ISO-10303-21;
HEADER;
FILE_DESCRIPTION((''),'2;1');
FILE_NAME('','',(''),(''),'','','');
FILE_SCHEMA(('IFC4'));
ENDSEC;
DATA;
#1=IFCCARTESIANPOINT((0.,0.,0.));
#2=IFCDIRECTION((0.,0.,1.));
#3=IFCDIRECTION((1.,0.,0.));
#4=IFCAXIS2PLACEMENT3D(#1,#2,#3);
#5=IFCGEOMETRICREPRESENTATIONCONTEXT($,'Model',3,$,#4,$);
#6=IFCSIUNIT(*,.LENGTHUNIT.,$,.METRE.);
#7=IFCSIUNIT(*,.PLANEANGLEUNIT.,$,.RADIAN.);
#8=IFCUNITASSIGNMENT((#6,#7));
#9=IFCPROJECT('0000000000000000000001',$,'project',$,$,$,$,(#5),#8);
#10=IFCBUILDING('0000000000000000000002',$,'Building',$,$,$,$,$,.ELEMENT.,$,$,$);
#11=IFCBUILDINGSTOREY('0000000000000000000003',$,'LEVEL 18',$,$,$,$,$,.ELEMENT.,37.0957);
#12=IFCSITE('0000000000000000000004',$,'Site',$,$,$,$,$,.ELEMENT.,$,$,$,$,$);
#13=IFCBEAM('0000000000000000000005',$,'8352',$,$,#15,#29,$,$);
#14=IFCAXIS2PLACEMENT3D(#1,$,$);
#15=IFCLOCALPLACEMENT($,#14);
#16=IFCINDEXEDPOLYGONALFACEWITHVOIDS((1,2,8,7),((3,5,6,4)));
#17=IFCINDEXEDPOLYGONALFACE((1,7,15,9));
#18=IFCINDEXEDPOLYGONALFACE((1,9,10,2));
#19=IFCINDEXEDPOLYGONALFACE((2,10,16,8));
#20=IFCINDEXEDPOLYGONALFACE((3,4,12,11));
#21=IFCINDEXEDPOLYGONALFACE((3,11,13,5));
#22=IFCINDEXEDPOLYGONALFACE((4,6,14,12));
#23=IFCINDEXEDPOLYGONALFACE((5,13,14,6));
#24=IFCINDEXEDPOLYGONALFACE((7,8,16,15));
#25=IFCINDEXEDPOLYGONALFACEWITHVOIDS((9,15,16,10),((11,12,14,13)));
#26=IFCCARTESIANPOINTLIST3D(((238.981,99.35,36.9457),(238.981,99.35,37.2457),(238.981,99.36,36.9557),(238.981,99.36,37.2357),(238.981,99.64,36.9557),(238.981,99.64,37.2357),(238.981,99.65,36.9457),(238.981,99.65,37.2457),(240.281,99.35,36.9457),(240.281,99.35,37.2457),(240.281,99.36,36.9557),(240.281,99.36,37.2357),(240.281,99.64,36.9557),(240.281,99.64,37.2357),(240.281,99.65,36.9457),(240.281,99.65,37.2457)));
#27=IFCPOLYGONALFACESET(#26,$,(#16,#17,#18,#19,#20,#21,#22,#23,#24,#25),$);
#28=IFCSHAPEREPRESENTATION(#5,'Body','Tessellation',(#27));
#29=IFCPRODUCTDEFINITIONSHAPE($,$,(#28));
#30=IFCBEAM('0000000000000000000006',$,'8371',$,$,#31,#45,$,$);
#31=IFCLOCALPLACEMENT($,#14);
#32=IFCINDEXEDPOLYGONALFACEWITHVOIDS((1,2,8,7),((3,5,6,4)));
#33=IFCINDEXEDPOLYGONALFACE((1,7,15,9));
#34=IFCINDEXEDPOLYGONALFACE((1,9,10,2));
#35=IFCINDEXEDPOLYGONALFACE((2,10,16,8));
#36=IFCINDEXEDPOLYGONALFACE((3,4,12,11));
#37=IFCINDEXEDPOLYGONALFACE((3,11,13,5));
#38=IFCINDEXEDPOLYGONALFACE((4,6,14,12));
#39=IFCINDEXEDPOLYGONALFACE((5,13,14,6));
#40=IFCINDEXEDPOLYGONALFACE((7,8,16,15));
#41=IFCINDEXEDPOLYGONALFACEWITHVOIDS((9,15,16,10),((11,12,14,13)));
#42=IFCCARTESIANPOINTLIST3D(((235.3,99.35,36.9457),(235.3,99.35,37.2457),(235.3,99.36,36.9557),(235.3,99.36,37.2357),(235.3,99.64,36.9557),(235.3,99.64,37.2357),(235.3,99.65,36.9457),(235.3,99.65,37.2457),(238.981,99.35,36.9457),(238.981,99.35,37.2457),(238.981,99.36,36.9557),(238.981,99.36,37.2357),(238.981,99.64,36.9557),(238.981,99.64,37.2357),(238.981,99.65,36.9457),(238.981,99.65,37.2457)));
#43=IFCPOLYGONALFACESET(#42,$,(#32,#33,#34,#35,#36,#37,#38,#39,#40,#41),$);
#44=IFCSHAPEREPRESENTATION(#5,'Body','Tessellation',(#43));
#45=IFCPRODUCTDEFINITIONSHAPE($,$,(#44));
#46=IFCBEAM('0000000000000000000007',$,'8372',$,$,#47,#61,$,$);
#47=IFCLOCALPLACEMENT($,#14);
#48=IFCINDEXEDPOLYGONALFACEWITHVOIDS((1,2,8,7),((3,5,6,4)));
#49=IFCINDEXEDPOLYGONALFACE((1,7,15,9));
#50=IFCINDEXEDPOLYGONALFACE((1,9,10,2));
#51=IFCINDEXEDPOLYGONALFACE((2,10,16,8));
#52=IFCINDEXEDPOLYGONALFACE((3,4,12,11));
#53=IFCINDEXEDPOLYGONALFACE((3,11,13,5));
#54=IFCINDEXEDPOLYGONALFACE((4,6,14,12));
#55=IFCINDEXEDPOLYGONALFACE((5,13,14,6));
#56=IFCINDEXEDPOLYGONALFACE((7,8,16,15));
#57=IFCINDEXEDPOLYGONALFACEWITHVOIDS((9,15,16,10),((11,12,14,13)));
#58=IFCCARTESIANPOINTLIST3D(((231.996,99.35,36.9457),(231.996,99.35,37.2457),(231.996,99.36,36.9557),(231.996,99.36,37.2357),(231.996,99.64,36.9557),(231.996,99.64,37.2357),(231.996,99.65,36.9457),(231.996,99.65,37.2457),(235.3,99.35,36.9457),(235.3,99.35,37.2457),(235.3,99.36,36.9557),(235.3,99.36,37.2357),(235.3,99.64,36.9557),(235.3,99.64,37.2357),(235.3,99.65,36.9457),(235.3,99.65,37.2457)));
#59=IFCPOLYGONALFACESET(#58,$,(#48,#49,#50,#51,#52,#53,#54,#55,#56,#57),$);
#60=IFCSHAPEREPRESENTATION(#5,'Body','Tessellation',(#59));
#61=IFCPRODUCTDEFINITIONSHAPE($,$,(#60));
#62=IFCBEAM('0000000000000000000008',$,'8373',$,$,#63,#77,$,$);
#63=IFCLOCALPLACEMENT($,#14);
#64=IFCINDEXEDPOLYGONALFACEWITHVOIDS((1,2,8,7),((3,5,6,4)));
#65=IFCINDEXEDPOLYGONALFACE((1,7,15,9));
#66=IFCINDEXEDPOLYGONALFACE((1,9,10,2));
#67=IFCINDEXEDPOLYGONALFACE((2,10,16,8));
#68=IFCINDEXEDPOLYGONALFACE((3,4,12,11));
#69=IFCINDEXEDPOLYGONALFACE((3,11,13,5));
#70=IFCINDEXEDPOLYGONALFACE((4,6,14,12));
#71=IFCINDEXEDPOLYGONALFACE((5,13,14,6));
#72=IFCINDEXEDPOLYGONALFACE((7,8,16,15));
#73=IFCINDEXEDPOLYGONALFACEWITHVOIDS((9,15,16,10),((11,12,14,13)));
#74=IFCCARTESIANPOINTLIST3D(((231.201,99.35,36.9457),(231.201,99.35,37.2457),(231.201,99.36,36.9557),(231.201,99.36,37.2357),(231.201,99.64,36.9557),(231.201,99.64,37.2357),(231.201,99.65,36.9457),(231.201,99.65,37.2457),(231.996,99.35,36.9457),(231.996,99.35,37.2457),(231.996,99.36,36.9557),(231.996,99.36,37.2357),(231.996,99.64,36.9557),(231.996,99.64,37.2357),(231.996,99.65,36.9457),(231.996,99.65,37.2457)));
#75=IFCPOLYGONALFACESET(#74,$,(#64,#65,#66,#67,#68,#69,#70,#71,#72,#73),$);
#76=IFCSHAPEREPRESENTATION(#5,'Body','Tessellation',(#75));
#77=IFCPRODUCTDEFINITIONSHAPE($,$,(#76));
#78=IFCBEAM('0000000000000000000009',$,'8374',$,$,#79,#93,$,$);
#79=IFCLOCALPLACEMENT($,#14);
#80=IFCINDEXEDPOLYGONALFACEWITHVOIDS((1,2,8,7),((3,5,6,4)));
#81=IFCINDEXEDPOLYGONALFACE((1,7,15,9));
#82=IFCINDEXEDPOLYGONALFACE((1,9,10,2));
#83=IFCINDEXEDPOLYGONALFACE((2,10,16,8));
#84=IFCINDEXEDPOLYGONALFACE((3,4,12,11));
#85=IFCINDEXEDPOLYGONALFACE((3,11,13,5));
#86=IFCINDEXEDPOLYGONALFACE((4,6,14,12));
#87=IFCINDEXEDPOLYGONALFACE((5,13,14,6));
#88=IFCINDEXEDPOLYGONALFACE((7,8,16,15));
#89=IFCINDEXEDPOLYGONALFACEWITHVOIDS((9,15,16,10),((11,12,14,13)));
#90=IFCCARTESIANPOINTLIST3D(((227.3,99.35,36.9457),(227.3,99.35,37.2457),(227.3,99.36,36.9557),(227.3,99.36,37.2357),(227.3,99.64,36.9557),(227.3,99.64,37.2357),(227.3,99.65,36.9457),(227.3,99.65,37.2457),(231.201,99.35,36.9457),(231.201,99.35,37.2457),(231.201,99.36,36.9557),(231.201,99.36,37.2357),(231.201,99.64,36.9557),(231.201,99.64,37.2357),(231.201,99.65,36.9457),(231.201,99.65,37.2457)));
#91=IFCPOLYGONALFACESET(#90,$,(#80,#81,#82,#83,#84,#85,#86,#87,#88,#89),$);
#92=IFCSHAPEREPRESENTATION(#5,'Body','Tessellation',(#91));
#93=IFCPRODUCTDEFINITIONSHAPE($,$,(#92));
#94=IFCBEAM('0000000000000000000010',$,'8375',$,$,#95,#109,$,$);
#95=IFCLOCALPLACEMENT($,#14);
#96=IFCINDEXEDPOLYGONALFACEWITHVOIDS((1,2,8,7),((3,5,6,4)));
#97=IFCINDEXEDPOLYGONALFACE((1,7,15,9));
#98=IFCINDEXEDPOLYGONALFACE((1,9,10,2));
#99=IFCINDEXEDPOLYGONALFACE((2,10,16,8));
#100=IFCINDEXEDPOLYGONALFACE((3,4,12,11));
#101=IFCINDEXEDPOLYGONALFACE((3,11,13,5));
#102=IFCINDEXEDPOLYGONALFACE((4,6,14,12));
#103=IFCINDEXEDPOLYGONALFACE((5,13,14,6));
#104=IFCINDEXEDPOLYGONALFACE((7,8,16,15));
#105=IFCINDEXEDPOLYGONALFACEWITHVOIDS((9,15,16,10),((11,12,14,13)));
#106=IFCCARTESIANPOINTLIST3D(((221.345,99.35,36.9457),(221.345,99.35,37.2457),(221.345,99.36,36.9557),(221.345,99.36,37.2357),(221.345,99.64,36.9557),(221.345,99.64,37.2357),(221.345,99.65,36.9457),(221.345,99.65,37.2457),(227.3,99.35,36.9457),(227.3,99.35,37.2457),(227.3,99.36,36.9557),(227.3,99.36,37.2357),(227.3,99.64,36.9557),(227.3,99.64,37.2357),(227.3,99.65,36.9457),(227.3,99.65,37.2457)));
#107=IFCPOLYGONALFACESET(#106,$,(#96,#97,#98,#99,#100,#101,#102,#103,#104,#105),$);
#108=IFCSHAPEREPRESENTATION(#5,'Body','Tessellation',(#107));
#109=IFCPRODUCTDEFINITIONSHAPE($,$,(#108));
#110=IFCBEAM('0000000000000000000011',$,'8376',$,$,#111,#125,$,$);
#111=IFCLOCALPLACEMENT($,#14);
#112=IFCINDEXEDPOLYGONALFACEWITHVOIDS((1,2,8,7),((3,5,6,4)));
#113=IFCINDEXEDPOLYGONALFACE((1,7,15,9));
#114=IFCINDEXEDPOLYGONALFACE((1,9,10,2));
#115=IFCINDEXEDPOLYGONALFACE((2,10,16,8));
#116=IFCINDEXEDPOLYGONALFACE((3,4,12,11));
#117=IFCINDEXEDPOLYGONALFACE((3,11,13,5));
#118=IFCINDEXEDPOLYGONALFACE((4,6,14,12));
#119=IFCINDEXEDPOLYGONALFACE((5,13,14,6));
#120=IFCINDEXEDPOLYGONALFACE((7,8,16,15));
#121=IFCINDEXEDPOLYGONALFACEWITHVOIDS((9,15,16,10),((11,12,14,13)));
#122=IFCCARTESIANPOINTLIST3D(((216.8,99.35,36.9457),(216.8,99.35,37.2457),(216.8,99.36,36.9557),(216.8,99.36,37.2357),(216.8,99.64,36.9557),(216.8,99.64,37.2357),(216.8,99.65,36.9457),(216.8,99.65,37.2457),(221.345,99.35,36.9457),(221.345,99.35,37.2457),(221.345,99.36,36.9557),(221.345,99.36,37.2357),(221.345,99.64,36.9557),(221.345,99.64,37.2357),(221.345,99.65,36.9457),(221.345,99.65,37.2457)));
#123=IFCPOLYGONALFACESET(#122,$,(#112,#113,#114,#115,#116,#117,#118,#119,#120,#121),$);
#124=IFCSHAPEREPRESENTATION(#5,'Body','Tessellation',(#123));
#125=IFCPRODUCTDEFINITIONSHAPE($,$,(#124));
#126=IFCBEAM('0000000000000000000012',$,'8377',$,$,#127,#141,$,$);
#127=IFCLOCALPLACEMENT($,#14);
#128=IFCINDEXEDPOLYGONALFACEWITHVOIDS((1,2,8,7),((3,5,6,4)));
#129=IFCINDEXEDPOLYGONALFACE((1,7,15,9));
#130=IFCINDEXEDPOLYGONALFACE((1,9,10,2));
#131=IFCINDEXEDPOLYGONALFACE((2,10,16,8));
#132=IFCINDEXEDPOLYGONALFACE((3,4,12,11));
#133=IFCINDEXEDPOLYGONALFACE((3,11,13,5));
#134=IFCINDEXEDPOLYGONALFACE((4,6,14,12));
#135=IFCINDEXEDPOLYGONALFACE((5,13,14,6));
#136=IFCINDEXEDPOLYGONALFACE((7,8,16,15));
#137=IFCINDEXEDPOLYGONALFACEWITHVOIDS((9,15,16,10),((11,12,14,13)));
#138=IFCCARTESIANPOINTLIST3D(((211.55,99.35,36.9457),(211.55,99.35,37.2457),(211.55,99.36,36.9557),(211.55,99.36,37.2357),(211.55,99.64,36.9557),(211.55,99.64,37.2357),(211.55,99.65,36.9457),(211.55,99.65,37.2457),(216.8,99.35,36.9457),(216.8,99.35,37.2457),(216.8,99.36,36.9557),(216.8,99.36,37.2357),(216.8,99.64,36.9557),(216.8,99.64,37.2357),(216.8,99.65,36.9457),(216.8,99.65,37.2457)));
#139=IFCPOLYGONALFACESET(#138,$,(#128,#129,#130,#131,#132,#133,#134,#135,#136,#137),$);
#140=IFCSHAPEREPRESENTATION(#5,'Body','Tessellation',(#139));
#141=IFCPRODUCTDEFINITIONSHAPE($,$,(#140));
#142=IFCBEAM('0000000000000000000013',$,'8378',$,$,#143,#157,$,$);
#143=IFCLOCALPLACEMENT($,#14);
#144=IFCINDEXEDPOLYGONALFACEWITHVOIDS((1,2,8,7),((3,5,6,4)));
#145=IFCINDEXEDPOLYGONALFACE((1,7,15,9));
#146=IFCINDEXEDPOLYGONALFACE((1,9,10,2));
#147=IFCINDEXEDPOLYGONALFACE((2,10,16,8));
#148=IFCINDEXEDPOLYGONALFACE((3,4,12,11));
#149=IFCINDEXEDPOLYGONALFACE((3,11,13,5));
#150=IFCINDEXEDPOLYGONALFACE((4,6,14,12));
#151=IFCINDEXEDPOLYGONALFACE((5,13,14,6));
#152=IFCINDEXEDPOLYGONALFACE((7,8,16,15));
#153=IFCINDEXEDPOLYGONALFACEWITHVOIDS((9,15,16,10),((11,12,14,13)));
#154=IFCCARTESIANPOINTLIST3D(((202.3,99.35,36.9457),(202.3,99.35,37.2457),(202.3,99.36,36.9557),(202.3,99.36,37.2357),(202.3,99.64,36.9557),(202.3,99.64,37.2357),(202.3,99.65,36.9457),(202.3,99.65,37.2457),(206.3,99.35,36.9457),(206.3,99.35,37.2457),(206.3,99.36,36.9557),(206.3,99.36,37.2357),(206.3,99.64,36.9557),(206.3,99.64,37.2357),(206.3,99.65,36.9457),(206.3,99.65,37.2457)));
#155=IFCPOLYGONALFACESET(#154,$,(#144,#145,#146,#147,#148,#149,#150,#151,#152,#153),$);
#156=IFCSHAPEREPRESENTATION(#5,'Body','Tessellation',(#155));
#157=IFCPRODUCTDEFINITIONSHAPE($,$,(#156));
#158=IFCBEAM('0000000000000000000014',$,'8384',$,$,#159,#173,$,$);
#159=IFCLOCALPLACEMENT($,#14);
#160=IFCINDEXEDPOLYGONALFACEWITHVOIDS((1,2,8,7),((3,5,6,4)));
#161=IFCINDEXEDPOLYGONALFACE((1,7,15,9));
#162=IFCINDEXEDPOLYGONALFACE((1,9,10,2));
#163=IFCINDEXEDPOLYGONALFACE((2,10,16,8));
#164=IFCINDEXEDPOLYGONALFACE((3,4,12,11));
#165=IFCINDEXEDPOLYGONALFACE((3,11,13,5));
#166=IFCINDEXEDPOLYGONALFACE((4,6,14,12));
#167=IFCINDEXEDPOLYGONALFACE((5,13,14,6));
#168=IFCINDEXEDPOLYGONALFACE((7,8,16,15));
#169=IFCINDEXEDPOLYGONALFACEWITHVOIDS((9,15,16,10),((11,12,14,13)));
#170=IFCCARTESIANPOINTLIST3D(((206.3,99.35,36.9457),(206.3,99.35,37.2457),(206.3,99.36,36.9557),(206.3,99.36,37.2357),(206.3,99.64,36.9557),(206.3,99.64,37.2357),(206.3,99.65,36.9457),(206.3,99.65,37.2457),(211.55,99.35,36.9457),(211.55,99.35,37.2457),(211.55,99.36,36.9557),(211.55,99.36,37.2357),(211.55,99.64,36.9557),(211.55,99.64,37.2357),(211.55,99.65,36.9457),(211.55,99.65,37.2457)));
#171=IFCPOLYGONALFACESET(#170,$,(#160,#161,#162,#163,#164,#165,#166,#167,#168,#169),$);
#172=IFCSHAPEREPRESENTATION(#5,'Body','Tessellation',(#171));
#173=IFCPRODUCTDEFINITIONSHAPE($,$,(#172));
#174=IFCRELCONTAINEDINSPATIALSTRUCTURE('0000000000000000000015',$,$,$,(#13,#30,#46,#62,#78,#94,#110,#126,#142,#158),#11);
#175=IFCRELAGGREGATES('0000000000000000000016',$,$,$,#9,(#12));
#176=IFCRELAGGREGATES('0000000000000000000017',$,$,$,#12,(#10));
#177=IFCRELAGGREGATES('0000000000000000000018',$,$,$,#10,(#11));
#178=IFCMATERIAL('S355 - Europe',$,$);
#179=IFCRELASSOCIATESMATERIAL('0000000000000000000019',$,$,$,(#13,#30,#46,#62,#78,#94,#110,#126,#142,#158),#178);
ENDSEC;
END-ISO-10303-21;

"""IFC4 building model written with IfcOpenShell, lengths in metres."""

from ifc_helpers import new_model, si_unit, frame, origin_with_axes, origin_2d_with_axis, place, context, project, spatial, hollow_rectangle, extrude, material, material_profile, profile_set, profile_usage, element, save


model = new_model("IFC4")

# Units and contexts
model_context = context("Model", 3, world=origin_with_axes())
ifc_project = project(units=[si_unit("LENGTHUNIT", "METRE"), si_unit("PLANEANGLEUNIT", "RADIAN")], contexts=[model_context])

# Site, building, storey
site = spatial("IfcSite", under=ifc_project, Name="Site", CompositionType="ELEMENT")
building = spatial("IfcBuilding", under=site, Name="Building", CompositionType="ELEMENT")
storey = spatial("IfcBuildingStorey", under=building, Name="LEVEL 18", CompositionType="ELEMENT", Elevation=37.0957)

# Beams
ifc_material = material(Name="S355 - Europe")
ifc_material_profile_1 = material_profile(ifc_material, hollow_rectangle(XDim=0.3, YDim=0.3, WallThickness=0.01, at=origin_2d_with_axis()))
ifc_profile_set_1 = profile_set([ifc_material_profile_1])
ifc_profile_usage_1 = profile_usage(ifc_profile_set_1, cardinal=10)
beam_1_placement = place(None, frame((238.981, 99.5, 37.0957), z_axis=(1.0, 0.0, 0.0), x_axis=(0.0, 1.0, 0.0)))
element("IfcBeam", 1, at=beam_1_placement, inside=storey, material=ifc_profile_usage_1, Name="8352", context=model_context, shape_type="SweptSolid", body=[
    extrude(hollow_rectangle(XDim=0.3, YDim=0.3, WallThickness=0.01, at=origin_2d_with_axis()), origin_with_axes(), (0.0, 0.0, 1.0), 1.3),
])
ifc_material_profile_2 = material_profile(ifc_material, hollow_rectangle(XDim=0.3, YDim=0.3, WallThickness=0.01, at=origin_2d_with_axis()))
ifc_profile_set_2 = profile_set([ifc_material_profile_2])
ifc_profile_usage_2 = profile_usage(ifc_profile_set_2, cardinal=10)
beam_2_placement = place(None, frame((235.3, 99.5, 37.0957), z_axis=(1.0, 0.0, 0.0), x_axis=(0.0, 1.0, 0.0)))
element("IfcBeam", 2, at=beam_2_placement, inside=storey, material=ifc_profile_usage_2, Name="8371", context=model_context, shape_type="SweptSolid", body=[
    extrude(hollow_rectangle(XDim=0.3, YDim=0.3, WallThickness=0.01, at=origin_2d_with_axis()), origin_with_axes(), (0.0, 0.0, 1.0), 3.681),
])
ifc_material_profile_3 = material_profile(ifc_material, hollow_rectangle(XDim=0.3, YDim=0.3, WallThickness=0.01, at=origin_2d_with_axis()))
ifc_profile_set_3 = profile_set([ifc_material_profile_3])
ifc_profile_usage_3 = profile_usage(ifc_profile_set_3, cardinal=10)
beam_3_placement = place(None, frame((231.996, 99.5, 37.0957), z_axis=(1.0, 0.0, 0.0), x_axis=(0.0, 1.0, 0.0)))
element("IfcBeam", 3, at=beam_3_placement, inside=storey, material=ifc_profile_usage_3, Name="8372", context=model_context, shape_type="SweptSolid", body=[
    extrude(hollow_rectangle(XDim=0.3, YDim=0.3, WallThickness=0.01, at=origin_2d_with_axis()), origin_with_axes(), (0.0, 0.0, 1.0), 3.304),
])
ifc_material_profile_4 = material_profile(ifc_material, hollow_rectangle(XDim=0.3, YDim=0.3, WallThickness=0.01, at=origin_2d_with_axis()))
ifc_profile_set_4 = profile_set([ifc_material_profile_4])
ifc_profile_usage_4 = profile_usage(ifc_profile_set_4, cardinal=10)
beam_4_placement = place(None, frame((231.201, 99.5, 37.0957), z_axis=(1.0, 0.0, 0.0), x_axis=(0.0, 1.0, 0.0)))
element("IfcBeam", 4, at=beam_4_placement, inside=storey, material=ifc_profile_usage_4, Name="8373", context=model_context, shape_type="SweptSolid", body=[
    extrude(hollow_rectangle(XDim=0.3, YDim=0.3, WallThickness=0.01, at=origin_2d_with_axis()), origin_with_axes(), (0.0, 0.0, 1.0), 0.795),
])
ifc_material_profile_5 = material_profile(ifc_material, hollow_rectangle(XDim=0.3, YDim=0.3, WallThickness=0.01, at=origin_2d_with_axis()))
ifc_profile_set_5 = profile_set([ifc_material_profile_5])
ifc_profile_usage_5 = profile_usage(ifc_profile_set_5, cardinal=10)
beam_5_placement = place(None, frame((227.3, 99.5, 37.0957), z_axis=(1.0, 0.0, 0.0), x_axis=(0.0, 1.0, 0.0)))
element("IfcBeam", 5, at=beam_5_placement, inside=storey, material=ifc_profile_usage_5, Name="8374", context=model_context, shape_type="SweptSolid", body=[
    extrude(hollow_rectangle(XDim=0.3, YDim=0.3, WallThickness=0.01, at=origin_2d_with_axis()), origin_with_axes(), (0.0, 0.0, 1.0), 3.901),
])
ifc_material_profile_6 = material_profile(ifc_material, hollow_rectangle(XDim=0.3, YDim=0.3, WallThickness=0.01, at=origin_2d_with_axis()))
ifc_profile_set_6 = profile_set([ifc_material_profile_6])
ifc_profile_usage_6 = profile_usage(ifc_profile_set_6, cardinal=10)
beam_6_placement = place(None, frame((221.345, 99.5, 37.0957), z_axis=(1.0, 0.0, 0.0), x_axis=(0.0, 1.0, 0.0)))
element("IfcBeam", 6, at=beam_6_placement, inside=storey, material=ifc_profile_usage_6, Name="8375", context=model_context, shape_type="SweptSolid", body=[
    extrude(hollow_rectangle(XDim=0.3, YDim=0.3, WallThickness=0.01, at=origin_2d_with_axis()), origin_with_axes(), (0.0, 0.0, 1.0), 5.955),
])
ifc_material_profile_7 = material_profile(ifc_material, hollow_rectangle(XDim=0.3, YDim=0.3, WallThickness=0.01, at=origin_2d_with_axis()))
ifc_profile_set_7 = profile_set([ifc_material_profile_7])
ifc_profile_usage_7 = profile_usage(ifc_profile_set_7, cardinal=10)
beam_7_placement = place(None, frame((216.8, 99.5, 37.0957), z_axis=(1.0, 0.0, 0.0), x_axis=(0.0, 1.0, 0.0)))
element("IfcBeam", 7, at=beam_7_placement, inside=storey, material=ifc_profile_usage_7, Name="8376", context=model_context, shape_type="SweptSolid", body=[
    extrude(hollow_rectangle(XDim=0.3, YDim=0.3, WallThickness=0.01, at=origin_2d_with_axis()), origin_with_axes(), (0.0, 0.0, 1.0), 4.545),
])
ifc_material_profile_8 = material_profile(ifc_material, hollow_rectangle(XDim=0.3, YDim=0.3, WallThickness=0.01, at=origin_2d_with_axis()))
ifc_profile_set_8 = profile_set([ifc_material_profile_8])
ifc_profile_usage_8 = profile_usage(ifc_profile_set_8, cardinal=10)
beam_8_placement = place(None, frame((211.55, 99.5, 37.0957), z_axis=(1.0, 0.0, 0.0), x_axis=(0.0, 1.0, 0.0)))
element("IfcBeam", 8, at=beam_8_placement, inside=storey, material=ifc_profile_usage_8, Name="8377", context=model_context, shape_type="SweptSolid", body=[
    extrude(hollow_rectangle(XDim=0.3, YDim=0.3, WallThickness=0.01, at=origin_2d_with_axis()), origin_with_axes(), (0.0, 0.0, 1.0), 5.25),
])
ifc_material_profile_9 = material_profile(ifc_material, hollow_rectangle(XDim=0.3, YDim=0.3, WallThickness=0.01, at=origin_2d_with_axis()))
ifc_profile_set_9 = profile_set([ifc_material_profile_9])
ifc_profile_usage_9 = profile_usage(ifc_profile_set_9, cardinal=10)
beam_9_placement = place(None, frame((202.3, 99.5, 37.0957), z_axis=(1.0, 0.0, 0.0), x_axis=(0.0, 1.0, 0.0)))
element("IfcBeam", 9, at=beam_9_placement, inside=storey, material=ifc_profile_usage_9, Name="8378", context=model_context, shape_type="SweptSolid", body=[
    extrude(hollow_rectangle(XDim=0.3, YDim=0.3, WallThickness=0.01, at=origin_2d_with_axis()), origin_with_axes(), (0.0, 0.0, 1.0), 4.0),
])
ifc_material_profile_10 = material_profile(ifc_material, hollow_rectangle(XDim=0.3, YDim=0.3, WallThickness=0.01, at=origin_2d_with_axis()))
ifc_profile_set_10 = profile_set([ifc_material_profile_10])
ifc_profile_usage_10 = profile_usage(ifc_profile_set_10, cardinal=10)
beam_10_placement = place(None, frame((206.3, 99.5, 37.0957), z_axis=(1.0, 0.0, 0.0), x_axis=(0.0, 1.0, 0.0)))
element("IfcBeam", 10, at=beam_10_placement, inside=storey, material=ifc_profile_usage_10, Name="8384", context=model_context, shape_type="SweptSolid", body=[
    extrude(hollow_rectangle(XDim=0.3, YDim=0.3, WallThickness=0.01, at=origin_2d_with_axis()), origin_with_axes(), (0.0, 0.0, 1.0), 5.25),
])

save(model, "model.ifc")
